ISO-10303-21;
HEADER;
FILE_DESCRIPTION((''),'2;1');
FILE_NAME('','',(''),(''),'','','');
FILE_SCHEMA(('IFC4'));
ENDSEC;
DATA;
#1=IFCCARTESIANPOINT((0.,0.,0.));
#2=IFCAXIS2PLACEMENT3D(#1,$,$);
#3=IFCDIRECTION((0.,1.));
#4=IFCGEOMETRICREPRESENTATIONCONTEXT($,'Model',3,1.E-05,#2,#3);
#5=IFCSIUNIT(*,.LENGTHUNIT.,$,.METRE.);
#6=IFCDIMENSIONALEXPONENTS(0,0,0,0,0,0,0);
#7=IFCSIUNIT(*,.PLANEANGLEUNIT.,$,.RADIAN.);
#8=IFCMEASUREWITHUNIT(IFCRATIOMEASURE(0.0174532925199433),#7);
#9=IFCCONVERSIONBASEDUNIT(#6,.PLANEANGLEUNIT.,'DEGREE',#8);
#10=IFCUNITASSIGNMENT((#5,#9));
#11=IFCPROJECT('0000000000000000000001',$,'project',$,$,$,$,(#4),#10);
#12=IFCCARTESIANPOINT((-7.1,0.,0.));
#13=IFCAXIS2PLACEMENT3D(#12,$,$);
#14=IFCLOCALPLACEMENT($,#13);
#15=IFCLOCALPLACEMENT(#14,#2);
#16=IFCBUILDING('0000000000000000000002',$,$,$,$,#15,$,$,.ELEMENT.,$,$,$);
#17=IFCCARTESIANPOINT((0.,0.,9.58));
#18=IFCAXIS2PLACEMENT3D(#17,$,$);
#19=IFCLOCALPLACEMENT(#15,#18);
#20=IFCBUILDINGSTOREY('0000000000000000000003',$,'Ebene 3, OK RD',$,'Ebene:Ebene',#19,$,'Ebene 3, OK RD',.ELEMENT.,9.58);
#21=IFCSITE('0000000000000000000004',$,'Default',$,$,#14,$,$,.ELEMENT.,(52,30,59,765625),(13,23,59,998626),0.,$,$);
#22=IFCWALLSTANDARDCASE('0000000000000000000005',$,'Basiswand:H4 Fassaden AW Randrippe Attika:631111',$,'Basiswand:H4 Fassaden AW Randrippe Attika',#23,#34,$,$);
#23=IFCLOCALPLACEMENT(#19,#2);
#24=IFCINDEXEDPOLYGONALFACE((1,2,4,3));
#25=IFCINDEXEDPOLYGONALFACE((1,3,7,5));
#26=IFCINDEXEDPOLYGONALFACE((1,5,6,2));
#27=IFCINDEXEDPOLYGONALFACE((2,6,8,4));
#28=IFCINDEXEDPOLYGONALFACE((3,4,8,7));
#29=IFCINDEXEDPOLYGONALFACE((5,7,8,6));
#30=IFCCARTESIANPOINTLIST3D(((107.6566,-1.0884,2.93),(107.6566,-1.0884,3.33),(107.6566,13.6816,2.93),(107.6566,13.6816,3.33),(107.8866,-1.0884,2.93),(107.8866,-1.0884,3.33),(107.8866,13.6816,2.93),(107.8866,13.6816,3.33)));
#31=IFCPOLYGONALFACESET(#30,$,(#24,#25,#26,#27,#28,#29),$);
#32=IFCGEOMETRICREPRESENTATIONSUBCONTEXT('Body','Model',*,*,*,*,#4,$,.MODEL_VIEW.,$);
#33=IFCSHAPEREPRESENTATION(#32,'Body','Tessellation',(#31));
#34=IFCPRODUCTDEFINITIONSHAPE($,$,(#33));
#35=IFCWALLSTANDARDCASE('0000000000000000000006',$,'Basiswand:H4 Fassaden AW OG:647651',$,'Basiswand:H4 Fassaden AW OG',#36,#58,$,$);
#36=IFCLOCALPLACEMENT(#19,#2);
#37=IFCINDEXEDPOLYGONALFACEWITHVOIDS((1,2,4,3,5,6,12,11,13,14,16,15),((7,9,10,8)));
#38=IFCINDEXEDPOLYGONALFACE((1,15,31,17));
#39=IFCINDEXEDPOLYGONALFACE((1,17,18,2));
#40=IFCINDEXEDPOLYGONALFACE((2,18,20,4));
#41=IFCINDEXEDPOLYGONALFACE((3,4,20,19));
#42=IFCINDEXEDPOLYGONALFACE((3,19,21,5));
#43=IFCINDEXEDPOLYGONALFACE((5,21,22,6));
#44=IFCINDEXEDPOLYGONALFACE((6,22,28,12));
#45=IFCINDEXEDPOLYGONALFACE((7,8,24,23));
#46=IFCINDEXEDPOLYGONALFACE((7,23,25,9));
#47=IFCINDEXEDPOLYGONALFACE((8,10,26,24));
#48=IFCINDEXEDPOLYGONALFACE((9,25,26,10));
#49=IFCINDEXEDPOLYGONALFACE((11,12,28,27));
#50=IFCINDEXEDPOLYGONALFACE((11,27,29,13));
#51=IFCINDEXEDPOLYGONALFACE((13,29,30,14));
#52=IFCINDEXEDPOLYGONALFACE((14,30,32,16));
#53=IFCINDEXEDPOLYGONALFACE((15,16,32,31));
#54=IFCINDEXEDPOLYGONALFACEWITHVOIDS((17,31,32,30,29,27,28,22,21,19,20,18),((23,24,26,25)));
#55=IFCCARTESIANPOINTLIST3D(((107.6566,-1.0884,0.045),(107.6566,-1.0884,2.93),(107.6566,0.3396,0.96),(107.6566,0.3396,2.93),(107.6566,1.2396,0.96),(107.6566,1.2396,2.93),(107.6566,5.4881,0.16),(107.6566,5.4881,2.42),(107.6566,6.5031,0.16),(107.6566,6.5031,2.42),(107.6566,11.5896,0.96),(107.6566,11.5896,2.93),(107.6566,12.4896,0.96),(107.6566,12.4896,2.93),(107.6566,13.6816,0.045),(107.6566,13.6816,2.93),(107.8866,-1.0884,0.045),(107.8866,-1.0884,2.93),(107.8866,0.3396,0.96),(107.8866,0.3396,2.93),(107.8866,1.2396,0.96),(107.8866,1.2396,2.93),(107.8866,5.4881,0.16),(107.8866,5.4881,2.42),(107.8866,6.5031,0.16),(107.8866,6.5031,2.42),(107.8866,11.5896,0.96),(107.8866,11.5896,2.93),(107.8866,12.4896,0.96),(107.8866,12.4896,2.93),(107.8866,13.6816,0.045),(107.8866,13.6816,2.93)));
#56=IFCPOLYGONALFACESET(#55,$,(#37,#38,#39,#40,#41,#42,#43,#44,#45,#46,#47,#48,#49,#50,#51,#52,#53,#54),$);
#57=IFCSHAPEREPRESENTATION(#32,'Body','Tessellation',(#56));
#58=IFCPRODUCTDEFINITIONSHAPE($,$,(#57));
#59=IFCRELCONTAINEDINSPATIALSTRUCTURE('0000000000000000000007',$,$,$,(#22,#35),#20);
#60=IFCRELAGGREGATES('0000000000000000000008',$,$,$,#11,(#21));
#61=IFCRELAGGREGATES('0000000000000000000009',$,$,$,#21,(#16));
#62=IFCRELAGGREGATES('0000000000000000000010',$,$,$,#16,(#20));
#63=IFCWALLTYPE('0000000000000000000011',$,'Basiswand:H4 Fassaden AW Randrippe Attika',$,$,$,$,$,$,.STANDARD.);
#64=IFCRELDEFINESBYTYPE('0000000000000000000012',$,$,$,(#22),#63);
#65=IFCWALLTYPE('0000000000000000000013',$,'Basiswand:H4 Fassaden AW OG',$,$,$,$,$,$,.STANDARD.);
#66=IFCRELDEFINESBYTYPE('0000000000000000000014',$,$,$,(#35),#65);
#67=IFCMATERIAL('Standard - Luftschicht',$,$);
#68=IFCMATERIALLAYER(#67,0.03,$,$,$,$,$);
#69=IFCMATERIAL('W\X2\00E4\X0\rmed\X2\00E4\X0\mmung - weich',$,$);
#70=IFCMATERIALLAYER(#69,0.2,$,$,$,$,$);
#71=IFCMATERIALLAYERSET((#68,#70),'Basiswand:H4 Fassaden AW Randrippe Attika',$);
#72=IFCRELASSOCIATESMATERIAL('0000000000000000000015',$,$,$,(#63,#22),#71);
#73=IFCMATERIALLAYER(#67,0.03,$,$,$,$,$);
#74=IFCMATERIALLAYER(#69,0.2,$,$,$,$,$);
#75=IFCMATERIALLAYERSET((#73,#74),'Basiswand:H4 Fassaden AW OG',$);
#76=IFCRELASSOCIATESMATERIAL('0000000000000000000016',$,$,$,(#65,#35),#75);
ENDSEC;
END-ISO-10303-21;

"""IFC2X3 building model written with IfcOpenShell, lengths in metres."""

from ifc_helpers import new_model, entity, si_unit, converted_unit, direction, frame, frame_2d, origin, place, context, subcontext, project, spatial, rectangle, extrude, material, layer, layer_set, layer_usage, type_object, element, save


model = new_model("IFC2X3")

# Units and contexts
model_context = context("Model", 3, precision=1e-05, world=origin(), true_north=direction((0.0, 1.0)))
body_context = subcontext(model_context, "Body", "Model", "MODEL_VIEW")
ifc_project = project(units=[si_unit("LENGTHUNIT", "METRE"), converted_unit("PLANEANGLEUNIT", "DEGREE", entity("IfcRatioMeasure", 0.0174532925199433), si_unit("PLANEANGLEUNIT", "RADIAN"), dimensions=[0, 0, 0, 0, 0, 0, 0])], contexts=[model_context])

# Site, building, storey
site_placement = place(None, frame((-7.1, 0.0, 0.0)))
site = spatial("IfcSite", under=ifc_project, at=site_placement, Name="Default", CompositionType="ELEMENT", RefLatitude=(52, 30, 59, 765625), RefLongitude=(13, 23, 59, 998626), RefElevation=0.0)
building_placement = place(site_placement, origin())
building = spatial("IfcBuilding", under=site, at=building_placement, CompositionType="ELEMENT")
storey_placement = place(building_placement, frame((0.0, 0.0, 9.58)))
storey = spatial("IfcBuildingStorey", under=building, at=storey_placement, Name="Ebene 3, OK RD", ObjectType="Ebene:Ebene", LongName="Ebene 3, OK RD", CompositionType="ELEMENT", Elevation=9.58)

# Wall
ifc_material_1 = material(Name="Standard - Luftschicht")
ifc_layer_1 = layer(ifc_material_1, 0.03)
ifc_material_2 = material(Name="Wärmedämmung - weich")
ifc_layer_2 = layer(ifc_material_2, 0.2)
ifc_layer_set_1 = layer_set([ifc_layer_1, ifc_layer_2], Name="Basiswand:H4 Fassaden AW Randrippe Attika")
wall_type_1 = type_object("IfcWallType", Name="Basiswand:H4 Fassaden AW Randrippe Attika", PredefinedType="STANDARD", material=ifc_layer_set_1)
ifc_layer_usage_1 = layer_usage(ifc_layer_set_1, "AXIS2", "NEGATIVE", 0.115)
wall_1_placement = place(storey_placement, frame((107.7716, 13.6816, 2.93), z_axis=(0.0, 0.0, 1.0), x_axis=(0.0, -1.0, 0.0)))
element("IfcWallStandardCase", 1, at=wall_1_placement, inside=storey, type_object=wall_type_1, material=ifc_layer_usage_1, Name="Basiswand:H4 Fassaden AW Randrippe Attika:631111", ObjectType="Basiswand:H4 Fassaden AW Randrippe Attika", context=body_context, shape_type="SweptSolid", body=[
    extrude(rectangle(XDim=14.77, YDim=0.23, at=frame_2d((7.385, 0.0), x_axis=(-1.0, 0.0))), origin(), (0.0, 0.0, 1.0), 0.4),
])

# Wall, openings
ifc_layer_3 = layer(ifc_material_1, 0.03)
ifc_layer_4 = layer(ifc_material_2, 0.2)
ifc_layer_set_2 = layer_set([ifc_layer_3, ifc_layer_4], Name="Basiswand:H4 Fassaden AW OG")
ifc_layer_usage_2 = layer_usage(ifc_layer_set_2, "AXIS2", "NEGATIVE", 0.115)
wall_type_2 = type_object("IfcWallType", Name="Basiswand:H4 Fassaden AW OG", PredefinedType="STANDARD", material=ifc_layer_set_2)
wall_2_placement = place(storey_placement, frame((107.7716, 13.6816, 0.045), z_axis=(0.0, 0.0, 1.0), x_axis=(0.0, -1.0, 0.0)))
wall_2 = element("IfcWallStandardCase", 2, at=wall_2_placement, inside=storey, type_object=wall_type_2, material=ifc_layer_usage_2, Name="Basiswand:H4 Fassaden AW OG:647651", ObjectType="Basiswand:H4 Fassaden AW OG", context=body_context, shape_type="SweptSolid", body=[
    extrude(rectangle(XDim=14.77, YDim=0.23, at=frame_2d((7.385, 0.0), x_axis=(-1.0, 0.0))), origin(), (0.0, 0.0, 1.0), 2.885),
])
opening_1_placement = place(wall_2_placement, frame((13.342, 0.115, 0.915)))
element("IfcOpeningElement", 3, at=opening_1_placement, cuts=wall_2, ObjectType="Opening", context=body_context, shape_type="SweptSolid", body=[
    extrude(rectangle(XDim=1.97, YDim=0.9, at=frame_2d((0.985, 0.45), x_axis=(1.0, 0.0))), frame((0.0, 0.0, 0.0), z_axis=(0.0, -1.0, 0.0), x_axis=(0.0, 0.0, 1.0)), (0.0, 0.0, 1.0), 0.23),
])
opening_2_placement = place(wall_2_placement, frame((2.092, 0.115, 0.915)))
element("IfcOpeningElement", 4, at=opening_2_placement, cuts=wall_2, ObjectType="Opening", context=body_context, shape_type="SweptSolid", body=[
    extrude(rectangle(XDim=1.97, YDim=0.9, at=frame_2d((0.985, 0.45), x_axis=(1.0, 0.0))), frame((0.0, 0.0, 0.0), z_axis=(0.0, -1.0, 0.0), x_axis=(0.0, 0.0, 1.0)), (0.0, 0.0, 1.0), 0.23),
])
opening_3_placement = place(wall_2_placement, frame((8.1935, 0.115, 0.115)))
element("IfcOpeningElement", 5, at=opening_3_placement, cuts=wall_2, ObjectType="Opening", context=body_context, shape_type="SweptSolid", body=[
    extrude(rectangle(XDim=2.26, YDim=1.015, at=frame_2d((1.13, 0.5075), x_axis=(1.0, 0.0))), frame((0.0, 0.0, 0.0), z_axis=(0.0, -1.0, 0.0), x_axis=(0.0, 0.0, 1.0)), (0.0, 0.0, 1.0), 0.23),
])

save(model, "model.ifc")
